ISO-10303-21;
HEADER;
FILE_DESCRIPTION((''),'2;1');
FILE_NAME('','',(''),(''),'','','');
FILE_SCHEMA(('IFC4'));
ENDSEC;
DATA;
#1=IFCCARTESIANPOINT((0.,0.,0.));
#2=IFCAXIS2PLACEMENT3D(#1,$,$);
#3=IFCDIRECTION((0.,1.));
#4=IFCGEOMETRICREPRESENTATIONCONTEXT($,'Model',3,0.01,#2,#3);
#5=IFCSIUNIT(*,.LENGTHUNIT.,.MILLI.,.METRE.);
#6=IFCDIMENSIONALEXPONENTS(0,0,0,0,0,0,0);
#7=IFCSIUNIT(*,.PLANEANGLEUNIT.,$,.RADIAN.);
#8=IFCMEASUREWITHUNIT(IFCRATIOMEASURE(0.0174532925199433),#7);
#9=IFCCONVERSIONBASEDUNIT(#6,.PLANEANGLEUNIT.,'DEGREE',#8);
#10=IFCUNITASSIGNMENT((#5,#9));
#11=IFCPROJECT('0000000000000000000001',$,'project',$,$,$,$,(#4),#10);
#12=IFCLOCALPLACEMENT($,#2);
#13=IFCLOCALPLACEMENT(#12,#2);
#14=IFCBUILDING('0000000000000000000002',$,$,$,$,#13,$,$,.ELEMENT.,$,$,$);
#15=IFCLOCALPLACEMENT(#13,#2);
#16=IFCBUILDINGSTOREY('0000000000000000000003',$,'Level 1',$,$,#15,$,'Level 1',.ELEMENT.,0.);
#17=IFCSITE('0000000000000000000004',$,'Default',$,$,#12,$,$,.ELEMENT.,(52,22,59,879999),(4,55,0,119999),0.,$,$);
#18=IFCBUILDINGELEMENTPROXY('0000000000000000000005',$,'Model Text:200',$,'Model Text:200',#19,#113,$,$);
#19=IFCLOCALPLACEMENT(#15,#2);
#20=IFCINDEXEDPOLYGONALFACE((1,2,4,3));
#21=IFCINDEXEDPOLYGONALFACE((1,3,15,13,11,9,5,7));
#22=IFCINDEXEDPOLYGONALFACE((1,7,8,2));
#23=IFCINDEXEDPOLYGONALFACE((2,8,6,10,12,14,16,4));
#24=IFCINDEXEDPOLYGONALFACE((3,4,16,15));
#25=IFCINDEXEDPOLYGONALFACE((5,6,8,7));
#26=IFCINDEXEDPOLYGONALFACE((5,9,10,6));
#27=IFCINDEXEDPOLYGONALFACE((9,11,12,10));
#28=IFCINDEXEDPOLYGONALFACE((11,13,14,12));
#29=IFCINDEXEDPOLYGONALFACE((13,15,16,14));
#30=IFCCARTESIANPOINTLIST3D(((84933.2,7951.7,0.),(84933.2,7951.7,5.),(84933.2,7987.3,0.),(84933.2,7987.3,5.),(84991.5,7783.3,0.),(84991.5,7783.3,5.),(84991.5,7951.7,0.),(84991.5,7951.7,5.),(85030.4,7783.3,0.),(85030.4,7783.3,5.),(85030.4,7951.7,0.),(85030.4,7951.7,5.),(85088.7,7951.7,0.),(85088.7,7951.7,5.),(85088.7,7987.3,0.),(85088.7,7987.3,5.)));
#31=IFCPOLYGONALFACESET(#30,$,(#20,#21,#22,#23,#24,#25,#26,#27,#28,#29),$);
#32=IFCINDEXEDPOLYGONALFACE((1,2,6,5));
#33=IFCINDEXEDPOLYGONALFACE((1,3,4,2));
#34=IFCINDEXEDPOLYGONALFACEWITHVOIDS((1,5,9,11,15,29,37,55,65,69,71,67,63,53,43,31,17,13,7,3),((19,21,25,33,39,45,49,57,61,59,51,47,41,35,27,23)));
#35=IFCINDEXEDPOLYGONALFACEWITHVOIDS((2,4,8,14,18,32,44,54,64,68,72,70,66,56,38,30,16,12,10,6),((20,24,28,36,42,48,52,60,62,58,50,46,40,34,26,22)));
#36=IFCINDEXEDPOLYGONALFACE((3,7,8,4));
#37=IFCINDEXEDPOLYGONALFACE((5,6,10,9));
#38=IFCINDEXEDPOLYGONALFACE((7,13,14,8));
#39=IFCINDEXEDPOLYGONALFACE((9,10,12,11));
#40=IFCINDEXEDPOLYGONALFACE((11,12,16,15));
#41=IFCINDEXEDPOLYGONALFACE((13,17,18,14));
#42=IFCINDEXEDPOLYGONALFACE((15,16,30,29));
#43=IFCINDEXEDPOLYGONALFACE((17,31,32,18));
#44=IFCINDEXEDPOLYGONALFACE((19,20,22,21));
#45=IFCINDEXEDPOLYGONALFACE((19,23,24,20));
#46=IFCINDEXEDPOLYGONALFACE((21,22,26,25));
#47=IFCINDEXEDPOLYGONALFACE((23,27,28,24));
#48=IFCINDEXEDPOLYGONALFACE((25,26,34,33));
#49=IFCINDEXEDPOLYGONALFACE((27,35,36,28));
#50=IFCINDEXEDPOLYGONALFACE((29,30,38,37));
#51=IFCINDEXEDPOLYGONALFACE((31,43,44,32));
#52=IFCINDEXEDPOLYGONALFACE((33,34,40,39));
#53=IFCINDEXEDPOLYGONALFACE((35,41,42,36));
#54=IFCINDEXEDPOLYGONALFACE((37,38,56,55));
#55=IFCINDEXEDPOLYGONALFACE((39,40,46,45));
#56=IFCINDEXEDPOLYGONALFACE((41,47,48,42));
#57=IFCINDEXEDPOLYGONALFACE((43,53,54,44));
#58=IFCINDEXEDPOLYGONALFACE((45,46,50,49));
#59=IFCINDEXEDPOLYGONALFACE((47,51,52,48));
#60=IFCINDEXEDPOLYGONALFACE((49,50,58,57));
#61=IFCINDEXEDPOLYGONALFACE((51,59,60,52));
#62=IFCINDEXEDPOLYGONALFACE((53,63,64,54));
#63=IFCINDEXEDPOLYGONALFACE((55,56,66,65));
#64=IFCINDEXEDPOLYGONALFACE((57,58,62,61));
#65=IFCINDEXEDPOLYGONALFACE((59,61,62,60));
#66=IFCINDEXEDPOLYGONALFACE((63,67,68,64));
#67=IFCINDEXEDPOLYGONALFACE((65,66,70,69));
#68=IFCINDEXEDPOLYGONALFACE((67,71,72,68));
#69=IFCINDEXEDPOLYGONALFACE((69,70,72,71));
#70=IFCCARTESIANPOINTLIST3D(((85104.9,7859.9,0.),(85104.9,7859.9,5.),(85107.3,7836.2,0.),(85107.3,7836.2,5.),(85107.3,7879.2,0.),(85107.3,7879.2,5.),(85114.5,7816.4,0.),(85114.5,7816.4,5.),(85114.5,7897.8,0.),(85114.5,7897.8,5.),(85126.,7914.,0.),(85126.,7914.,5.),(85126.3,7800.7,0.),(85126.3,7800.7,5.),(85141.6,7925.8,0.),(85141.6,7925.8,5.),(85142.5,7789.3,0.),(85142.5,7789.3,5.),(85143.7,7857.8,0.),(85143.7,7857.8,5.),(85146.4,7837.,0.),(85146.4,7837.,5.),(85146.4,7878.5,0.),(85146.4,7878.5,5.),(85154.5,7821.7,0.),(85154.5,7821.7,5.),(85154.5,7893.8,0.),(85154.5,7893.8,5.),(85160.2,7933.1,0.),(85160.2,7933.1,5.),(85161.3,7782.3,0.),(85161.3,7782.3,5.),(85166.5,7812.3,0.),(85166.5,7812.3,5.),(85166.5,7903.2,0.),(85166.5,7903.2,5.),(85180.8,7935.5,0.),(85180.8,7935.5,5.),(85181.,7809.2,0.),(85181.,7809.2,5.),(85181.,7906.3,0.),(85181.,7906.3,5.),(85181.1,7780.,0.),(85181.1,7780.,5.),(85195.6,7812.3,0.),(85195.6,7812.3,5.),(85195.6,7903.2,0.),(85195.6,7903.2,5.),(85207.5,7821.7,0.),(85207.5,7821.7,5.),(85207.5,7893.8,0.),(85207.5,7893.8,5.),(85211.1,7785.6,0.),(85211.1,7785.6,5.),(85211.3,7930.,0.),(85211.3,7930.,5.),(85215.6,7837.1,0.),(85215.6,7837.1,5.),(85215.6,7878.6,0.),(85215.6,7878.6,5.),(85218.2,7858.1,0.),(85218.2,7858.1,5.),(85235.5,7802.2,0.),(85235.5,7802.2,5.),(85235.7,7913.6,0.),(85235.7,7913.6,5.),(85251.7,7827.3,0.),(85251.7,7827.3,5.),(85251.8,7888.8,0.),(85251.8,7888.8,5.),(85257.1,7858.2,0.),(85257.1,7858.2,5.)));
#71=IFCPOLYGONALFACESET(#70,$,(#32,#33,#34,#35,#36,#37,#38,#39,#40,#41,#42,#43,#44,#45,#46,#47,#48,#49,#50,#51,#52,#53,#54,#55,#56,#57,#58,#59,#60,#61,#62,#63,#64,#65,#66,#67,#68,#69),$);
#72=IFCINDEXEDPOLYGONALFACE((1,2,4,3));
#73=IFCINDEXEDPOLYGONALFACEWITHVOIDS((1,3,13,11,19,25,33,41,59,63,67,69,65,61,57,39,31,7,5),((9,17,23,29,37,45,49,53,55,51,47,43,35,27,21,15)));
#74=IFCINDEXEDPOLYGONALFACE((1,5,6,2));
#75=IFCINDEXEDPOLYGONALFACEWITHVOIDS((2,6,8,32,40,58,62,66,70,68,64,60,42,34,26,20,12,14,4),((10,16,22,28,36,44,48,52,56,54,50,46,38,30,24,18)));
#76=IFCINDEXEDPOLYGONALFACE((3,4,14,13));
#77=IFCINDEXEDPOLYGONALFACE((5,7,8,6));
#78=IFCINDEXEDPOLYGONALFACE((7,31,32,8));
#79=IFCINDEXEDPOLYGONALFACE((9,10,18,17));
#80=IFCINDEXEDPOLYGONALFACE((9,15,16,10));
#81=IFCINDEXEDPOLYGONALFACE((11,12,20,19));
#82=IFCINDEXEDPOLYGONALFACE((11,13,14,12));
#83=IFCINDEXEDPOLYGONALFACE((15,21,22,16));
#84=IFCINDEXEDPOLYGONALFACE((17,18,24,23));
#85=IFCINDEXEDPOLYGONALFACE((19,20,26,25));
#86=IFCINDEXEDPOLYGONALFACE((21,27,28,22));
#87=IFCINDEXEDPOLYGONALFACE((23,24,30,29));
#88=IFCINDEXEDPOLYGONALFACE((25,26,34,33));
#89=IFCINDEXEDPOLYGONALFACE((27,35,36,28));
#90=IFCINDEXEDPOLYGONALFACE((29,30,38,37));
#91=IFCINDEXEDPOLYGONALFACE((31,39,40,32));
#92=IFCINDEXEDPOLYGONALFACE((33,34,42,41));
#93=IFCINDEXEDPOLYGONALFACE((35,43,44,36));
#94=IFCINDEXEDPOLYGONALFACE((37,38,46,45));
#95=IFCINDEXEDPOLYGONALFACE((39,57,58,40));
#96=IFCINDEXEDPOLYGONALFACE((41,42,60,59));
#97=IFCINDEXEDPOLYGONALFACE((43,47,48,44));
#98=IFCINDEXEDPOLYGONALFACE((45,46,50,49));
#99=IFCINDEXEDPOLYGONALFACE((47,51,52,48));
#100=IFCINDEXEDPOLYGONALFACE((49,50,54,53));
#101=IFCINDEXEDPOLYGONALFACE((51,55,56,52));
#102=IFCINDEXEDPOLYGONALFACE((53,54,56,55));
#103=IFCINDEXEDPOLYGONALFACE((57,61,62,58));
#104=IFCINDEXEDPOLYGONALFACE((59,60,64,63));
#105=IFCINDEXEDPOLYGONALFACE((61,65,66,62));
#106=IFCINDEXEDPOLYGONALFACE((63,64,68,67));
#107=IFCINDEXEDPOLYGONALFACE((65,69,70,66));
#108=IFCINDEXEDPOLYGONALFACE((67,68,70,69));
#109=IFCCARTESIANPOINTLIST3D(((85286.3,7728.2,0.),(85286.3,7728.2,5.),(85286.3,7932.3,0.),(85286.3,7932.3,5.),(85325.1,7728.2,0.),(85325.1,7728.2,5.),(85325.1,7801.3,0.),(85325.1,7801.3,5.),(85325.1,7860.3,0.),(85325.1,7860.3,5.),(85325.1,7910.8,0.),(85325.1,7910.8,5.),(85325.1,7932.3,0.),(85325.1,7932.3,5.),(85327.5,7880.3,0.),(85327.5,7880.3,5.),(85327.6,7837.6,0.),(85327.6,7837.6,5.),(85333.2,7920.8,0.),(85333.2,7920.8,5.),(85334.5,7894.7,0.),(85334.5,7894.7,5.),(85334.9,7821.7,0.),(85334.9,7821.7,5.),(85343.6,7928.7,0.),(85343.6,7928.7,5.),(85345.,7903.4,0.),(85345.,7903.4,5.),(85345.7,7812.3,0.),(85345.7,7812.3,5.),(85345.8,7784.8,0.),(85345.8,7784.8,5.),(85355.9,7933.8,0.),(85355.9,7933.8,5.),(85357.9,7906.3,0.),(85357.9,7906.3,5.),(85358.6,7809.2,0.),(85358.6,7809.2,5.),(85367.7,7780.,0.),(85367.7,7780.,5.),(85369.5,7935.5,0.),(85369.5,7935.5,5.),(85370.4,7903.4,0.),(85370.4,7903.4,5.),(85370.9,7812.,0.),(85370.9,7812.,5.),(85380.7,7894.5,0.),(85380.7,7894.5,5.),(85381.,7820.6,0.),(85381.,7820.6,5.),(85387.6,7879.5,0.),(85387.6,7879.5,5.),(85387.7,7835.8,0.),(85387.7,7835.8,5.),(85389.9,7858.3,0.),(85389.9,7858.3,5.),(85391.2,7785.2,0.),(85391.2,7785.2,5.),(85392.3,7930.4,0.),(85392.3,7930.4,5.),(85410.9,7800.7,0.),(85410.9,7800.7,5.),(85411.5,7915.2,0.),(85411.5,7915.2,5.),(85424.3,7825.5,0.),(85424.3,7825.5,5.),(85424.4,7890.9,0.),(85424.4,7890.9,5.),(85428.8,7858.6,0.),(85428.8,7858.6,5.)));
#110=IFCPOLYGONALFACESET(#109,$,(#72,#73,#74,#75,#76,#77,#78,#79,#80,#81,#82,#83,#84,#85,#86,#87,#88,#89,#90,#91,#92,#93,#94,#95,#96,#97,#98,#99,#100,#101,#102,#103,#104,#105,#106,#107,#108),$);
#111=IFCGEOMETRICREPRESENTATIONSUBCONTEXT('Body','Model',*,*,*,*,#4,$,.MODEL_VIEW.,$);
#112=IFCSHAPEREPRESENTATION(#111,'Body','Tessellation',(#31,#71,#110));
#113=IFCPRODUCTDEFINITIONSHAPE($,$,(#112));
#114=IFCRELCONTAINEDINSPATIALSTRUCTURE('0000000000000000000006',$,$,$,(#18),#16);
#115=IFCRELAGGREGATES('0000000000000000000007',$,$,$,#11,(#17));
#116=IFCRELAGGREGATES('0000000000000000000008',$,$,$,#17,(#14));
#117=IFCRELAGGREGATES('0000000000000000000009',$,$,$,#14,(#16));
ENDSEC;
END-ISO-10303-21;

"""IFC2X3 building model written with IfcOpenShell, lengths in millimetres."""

from ifc_helpers import new_model, entity, si_unit, converted_unit, direction, frame, origin, place, context, subcontext, project, spatial, polyline, outline, extrude, element, save


model = new_model("IFC2X3")

# Units and contexts
model_context = context("Model", 3, precision=0.01, world=origin(), true_north=direction((0.0, 1.0)))
body_context = subcontext(model_context, "Body", "Model", "MODEL_VIEW")
ifc_project = project(units=[si_unit("LENGTHUNIT", "METRE", prefix="MILLI"), converted_unit("PLANEANGLEUNIT", "DEGREE", entity("IfcRatioMeasure", 0.0174532925199433), si_unit("PLANEANGLEUNIT", "RADIAN"), dimensions=[0, 0, 0, 0, 0, 0, 0])], contexts=[model_context])

# Site, building, storey
site_placement = place(None, origin())
site = spatial("IfcSite", under=ifc_project, at=site_placement, Name="Default", CompositionType="ELEMENT", RefLatitude=(52, 22, 59, 879999), RefLongitude=(4, 55, 0, 119999), RefElevation=0.0)
building_placement = place(site_placement, origin())
building = spatial("IfcBuilding", under=site, at=building_placement, CompositionType="ELEMENT")
storey_placement = place(building_placement, origin())
storey = spatial("IfcBuildingStorey", under=building, at=storey_placement, Name="Level 1", LongName="Level 1", CompositionType="ELEMENT", Elevation=0.0)

# Building element proxy
proxy_1_placement = place(building_placement, origin())
element("IfcBuildingElementProxy", 1, at=proxy_1_placement, inside=storey, Name="Model Text:200", ObjectType="Model Text:200", context=body_context, shape_type="SweptSolid", body=[
    extrude(outline(polyline([(-19.4, -135.2), (19.4, -135.2), (19.4, 33.2), (77.7, 33.2), (77.7, 68.8), (-77.7, 68.8), (-77.7, 33.2), (-19.4, 33.2), (-19.4, -135.2)])), frame((85010.9, 7918.5, 0.0)), (0.0, 0.0, 1.0), 5.0),
    extrude(outline(polyline([(-8.8, -65.7), (15.1, -65.7), (35.5, -60.5), (52.3, -50.4), (65.3, -35.4), (74.1, -17.3), (78.4, 2.1), (75.9, 32.5), (61.8, 58.5), (38.4, 77.1), (8.3, 85.6), (-22.7, 83.3), (-49.0, 69.9), (-67.8, 47.3), (-76.3, 17.5), (-76.0, -3.3), (-70.7, -22.5), (-60.5, -39.2), (-45.5, -52.3), (-27.7, -61.4), (-8.8, -65.7)]), holes=[polyline([(-2.7, -27.2), (-23.1, -22.5), (-37.5, -12.9), (-45.7, 0.0), (-47.3, 14.8), (-42.7, 28.9), (-32.2, 39.9), (-16.3, 46.3), (4.5, 46.9), (25.1, 42.1), (39.6, 32.6), (47.7, 19.7), (49.4, 5.0), (44.8, -9.2), (34.2, -20.2), (18.2, -26.7), (-2.7, -27.2)])]), frame((85171.1, 7857.8, 0.0), z_axis=(0.0, 0.0, 1.0), x_axis=(0.100608, -0.994926, 0.0)), (0.0, 0.0, 1.0), 5.0),
    extrude(outline(polyline([(-73.1, -75.4), (130.9, -75.4), (130.9, -36.6), (57.8, -36.6), (74.3, -15.9), (79.1, 6.0), (73.9, 29.5), (58.4, 49.2), (33.6, 62.6), (0.5, 67.1), (-31.8, 62.8), (-56.1, 49.8), (-71.3, 30.7), (-76.4, 7.8), (-74.7, -5.8), (-69.6, -18.1), (-61.7, -28.5), (-51.7, -36.6), (-73.1, -36.6), (-73.1, -75.4)]), holes=[polyline([(-1.2, -36.6), (-21.2, -34.2), (-35.6, -27.2), (-44.3, -16.7), (-47.2, -3.8), (-44.3, 8.7), (-35.4, 19.0), (-20.4, 25.9), (0.8, 28.2), (23.3, 26.0), (38.5, 19.3), (47.1, 9.2), (49.9, -3.1), (46.8, -16.0), (37.4, -26.8), (21.5, -34.1), (-1.2, -36.6)])]), frame((85361.7, 7859.1, 0.0), z_axis=(0.0, 0.0, 1.0), x_axis=(0.0, -1.0, 0.0)), (0.0, 0.0, 1.0), 5.0),
])

save(model, "model.ifc")
